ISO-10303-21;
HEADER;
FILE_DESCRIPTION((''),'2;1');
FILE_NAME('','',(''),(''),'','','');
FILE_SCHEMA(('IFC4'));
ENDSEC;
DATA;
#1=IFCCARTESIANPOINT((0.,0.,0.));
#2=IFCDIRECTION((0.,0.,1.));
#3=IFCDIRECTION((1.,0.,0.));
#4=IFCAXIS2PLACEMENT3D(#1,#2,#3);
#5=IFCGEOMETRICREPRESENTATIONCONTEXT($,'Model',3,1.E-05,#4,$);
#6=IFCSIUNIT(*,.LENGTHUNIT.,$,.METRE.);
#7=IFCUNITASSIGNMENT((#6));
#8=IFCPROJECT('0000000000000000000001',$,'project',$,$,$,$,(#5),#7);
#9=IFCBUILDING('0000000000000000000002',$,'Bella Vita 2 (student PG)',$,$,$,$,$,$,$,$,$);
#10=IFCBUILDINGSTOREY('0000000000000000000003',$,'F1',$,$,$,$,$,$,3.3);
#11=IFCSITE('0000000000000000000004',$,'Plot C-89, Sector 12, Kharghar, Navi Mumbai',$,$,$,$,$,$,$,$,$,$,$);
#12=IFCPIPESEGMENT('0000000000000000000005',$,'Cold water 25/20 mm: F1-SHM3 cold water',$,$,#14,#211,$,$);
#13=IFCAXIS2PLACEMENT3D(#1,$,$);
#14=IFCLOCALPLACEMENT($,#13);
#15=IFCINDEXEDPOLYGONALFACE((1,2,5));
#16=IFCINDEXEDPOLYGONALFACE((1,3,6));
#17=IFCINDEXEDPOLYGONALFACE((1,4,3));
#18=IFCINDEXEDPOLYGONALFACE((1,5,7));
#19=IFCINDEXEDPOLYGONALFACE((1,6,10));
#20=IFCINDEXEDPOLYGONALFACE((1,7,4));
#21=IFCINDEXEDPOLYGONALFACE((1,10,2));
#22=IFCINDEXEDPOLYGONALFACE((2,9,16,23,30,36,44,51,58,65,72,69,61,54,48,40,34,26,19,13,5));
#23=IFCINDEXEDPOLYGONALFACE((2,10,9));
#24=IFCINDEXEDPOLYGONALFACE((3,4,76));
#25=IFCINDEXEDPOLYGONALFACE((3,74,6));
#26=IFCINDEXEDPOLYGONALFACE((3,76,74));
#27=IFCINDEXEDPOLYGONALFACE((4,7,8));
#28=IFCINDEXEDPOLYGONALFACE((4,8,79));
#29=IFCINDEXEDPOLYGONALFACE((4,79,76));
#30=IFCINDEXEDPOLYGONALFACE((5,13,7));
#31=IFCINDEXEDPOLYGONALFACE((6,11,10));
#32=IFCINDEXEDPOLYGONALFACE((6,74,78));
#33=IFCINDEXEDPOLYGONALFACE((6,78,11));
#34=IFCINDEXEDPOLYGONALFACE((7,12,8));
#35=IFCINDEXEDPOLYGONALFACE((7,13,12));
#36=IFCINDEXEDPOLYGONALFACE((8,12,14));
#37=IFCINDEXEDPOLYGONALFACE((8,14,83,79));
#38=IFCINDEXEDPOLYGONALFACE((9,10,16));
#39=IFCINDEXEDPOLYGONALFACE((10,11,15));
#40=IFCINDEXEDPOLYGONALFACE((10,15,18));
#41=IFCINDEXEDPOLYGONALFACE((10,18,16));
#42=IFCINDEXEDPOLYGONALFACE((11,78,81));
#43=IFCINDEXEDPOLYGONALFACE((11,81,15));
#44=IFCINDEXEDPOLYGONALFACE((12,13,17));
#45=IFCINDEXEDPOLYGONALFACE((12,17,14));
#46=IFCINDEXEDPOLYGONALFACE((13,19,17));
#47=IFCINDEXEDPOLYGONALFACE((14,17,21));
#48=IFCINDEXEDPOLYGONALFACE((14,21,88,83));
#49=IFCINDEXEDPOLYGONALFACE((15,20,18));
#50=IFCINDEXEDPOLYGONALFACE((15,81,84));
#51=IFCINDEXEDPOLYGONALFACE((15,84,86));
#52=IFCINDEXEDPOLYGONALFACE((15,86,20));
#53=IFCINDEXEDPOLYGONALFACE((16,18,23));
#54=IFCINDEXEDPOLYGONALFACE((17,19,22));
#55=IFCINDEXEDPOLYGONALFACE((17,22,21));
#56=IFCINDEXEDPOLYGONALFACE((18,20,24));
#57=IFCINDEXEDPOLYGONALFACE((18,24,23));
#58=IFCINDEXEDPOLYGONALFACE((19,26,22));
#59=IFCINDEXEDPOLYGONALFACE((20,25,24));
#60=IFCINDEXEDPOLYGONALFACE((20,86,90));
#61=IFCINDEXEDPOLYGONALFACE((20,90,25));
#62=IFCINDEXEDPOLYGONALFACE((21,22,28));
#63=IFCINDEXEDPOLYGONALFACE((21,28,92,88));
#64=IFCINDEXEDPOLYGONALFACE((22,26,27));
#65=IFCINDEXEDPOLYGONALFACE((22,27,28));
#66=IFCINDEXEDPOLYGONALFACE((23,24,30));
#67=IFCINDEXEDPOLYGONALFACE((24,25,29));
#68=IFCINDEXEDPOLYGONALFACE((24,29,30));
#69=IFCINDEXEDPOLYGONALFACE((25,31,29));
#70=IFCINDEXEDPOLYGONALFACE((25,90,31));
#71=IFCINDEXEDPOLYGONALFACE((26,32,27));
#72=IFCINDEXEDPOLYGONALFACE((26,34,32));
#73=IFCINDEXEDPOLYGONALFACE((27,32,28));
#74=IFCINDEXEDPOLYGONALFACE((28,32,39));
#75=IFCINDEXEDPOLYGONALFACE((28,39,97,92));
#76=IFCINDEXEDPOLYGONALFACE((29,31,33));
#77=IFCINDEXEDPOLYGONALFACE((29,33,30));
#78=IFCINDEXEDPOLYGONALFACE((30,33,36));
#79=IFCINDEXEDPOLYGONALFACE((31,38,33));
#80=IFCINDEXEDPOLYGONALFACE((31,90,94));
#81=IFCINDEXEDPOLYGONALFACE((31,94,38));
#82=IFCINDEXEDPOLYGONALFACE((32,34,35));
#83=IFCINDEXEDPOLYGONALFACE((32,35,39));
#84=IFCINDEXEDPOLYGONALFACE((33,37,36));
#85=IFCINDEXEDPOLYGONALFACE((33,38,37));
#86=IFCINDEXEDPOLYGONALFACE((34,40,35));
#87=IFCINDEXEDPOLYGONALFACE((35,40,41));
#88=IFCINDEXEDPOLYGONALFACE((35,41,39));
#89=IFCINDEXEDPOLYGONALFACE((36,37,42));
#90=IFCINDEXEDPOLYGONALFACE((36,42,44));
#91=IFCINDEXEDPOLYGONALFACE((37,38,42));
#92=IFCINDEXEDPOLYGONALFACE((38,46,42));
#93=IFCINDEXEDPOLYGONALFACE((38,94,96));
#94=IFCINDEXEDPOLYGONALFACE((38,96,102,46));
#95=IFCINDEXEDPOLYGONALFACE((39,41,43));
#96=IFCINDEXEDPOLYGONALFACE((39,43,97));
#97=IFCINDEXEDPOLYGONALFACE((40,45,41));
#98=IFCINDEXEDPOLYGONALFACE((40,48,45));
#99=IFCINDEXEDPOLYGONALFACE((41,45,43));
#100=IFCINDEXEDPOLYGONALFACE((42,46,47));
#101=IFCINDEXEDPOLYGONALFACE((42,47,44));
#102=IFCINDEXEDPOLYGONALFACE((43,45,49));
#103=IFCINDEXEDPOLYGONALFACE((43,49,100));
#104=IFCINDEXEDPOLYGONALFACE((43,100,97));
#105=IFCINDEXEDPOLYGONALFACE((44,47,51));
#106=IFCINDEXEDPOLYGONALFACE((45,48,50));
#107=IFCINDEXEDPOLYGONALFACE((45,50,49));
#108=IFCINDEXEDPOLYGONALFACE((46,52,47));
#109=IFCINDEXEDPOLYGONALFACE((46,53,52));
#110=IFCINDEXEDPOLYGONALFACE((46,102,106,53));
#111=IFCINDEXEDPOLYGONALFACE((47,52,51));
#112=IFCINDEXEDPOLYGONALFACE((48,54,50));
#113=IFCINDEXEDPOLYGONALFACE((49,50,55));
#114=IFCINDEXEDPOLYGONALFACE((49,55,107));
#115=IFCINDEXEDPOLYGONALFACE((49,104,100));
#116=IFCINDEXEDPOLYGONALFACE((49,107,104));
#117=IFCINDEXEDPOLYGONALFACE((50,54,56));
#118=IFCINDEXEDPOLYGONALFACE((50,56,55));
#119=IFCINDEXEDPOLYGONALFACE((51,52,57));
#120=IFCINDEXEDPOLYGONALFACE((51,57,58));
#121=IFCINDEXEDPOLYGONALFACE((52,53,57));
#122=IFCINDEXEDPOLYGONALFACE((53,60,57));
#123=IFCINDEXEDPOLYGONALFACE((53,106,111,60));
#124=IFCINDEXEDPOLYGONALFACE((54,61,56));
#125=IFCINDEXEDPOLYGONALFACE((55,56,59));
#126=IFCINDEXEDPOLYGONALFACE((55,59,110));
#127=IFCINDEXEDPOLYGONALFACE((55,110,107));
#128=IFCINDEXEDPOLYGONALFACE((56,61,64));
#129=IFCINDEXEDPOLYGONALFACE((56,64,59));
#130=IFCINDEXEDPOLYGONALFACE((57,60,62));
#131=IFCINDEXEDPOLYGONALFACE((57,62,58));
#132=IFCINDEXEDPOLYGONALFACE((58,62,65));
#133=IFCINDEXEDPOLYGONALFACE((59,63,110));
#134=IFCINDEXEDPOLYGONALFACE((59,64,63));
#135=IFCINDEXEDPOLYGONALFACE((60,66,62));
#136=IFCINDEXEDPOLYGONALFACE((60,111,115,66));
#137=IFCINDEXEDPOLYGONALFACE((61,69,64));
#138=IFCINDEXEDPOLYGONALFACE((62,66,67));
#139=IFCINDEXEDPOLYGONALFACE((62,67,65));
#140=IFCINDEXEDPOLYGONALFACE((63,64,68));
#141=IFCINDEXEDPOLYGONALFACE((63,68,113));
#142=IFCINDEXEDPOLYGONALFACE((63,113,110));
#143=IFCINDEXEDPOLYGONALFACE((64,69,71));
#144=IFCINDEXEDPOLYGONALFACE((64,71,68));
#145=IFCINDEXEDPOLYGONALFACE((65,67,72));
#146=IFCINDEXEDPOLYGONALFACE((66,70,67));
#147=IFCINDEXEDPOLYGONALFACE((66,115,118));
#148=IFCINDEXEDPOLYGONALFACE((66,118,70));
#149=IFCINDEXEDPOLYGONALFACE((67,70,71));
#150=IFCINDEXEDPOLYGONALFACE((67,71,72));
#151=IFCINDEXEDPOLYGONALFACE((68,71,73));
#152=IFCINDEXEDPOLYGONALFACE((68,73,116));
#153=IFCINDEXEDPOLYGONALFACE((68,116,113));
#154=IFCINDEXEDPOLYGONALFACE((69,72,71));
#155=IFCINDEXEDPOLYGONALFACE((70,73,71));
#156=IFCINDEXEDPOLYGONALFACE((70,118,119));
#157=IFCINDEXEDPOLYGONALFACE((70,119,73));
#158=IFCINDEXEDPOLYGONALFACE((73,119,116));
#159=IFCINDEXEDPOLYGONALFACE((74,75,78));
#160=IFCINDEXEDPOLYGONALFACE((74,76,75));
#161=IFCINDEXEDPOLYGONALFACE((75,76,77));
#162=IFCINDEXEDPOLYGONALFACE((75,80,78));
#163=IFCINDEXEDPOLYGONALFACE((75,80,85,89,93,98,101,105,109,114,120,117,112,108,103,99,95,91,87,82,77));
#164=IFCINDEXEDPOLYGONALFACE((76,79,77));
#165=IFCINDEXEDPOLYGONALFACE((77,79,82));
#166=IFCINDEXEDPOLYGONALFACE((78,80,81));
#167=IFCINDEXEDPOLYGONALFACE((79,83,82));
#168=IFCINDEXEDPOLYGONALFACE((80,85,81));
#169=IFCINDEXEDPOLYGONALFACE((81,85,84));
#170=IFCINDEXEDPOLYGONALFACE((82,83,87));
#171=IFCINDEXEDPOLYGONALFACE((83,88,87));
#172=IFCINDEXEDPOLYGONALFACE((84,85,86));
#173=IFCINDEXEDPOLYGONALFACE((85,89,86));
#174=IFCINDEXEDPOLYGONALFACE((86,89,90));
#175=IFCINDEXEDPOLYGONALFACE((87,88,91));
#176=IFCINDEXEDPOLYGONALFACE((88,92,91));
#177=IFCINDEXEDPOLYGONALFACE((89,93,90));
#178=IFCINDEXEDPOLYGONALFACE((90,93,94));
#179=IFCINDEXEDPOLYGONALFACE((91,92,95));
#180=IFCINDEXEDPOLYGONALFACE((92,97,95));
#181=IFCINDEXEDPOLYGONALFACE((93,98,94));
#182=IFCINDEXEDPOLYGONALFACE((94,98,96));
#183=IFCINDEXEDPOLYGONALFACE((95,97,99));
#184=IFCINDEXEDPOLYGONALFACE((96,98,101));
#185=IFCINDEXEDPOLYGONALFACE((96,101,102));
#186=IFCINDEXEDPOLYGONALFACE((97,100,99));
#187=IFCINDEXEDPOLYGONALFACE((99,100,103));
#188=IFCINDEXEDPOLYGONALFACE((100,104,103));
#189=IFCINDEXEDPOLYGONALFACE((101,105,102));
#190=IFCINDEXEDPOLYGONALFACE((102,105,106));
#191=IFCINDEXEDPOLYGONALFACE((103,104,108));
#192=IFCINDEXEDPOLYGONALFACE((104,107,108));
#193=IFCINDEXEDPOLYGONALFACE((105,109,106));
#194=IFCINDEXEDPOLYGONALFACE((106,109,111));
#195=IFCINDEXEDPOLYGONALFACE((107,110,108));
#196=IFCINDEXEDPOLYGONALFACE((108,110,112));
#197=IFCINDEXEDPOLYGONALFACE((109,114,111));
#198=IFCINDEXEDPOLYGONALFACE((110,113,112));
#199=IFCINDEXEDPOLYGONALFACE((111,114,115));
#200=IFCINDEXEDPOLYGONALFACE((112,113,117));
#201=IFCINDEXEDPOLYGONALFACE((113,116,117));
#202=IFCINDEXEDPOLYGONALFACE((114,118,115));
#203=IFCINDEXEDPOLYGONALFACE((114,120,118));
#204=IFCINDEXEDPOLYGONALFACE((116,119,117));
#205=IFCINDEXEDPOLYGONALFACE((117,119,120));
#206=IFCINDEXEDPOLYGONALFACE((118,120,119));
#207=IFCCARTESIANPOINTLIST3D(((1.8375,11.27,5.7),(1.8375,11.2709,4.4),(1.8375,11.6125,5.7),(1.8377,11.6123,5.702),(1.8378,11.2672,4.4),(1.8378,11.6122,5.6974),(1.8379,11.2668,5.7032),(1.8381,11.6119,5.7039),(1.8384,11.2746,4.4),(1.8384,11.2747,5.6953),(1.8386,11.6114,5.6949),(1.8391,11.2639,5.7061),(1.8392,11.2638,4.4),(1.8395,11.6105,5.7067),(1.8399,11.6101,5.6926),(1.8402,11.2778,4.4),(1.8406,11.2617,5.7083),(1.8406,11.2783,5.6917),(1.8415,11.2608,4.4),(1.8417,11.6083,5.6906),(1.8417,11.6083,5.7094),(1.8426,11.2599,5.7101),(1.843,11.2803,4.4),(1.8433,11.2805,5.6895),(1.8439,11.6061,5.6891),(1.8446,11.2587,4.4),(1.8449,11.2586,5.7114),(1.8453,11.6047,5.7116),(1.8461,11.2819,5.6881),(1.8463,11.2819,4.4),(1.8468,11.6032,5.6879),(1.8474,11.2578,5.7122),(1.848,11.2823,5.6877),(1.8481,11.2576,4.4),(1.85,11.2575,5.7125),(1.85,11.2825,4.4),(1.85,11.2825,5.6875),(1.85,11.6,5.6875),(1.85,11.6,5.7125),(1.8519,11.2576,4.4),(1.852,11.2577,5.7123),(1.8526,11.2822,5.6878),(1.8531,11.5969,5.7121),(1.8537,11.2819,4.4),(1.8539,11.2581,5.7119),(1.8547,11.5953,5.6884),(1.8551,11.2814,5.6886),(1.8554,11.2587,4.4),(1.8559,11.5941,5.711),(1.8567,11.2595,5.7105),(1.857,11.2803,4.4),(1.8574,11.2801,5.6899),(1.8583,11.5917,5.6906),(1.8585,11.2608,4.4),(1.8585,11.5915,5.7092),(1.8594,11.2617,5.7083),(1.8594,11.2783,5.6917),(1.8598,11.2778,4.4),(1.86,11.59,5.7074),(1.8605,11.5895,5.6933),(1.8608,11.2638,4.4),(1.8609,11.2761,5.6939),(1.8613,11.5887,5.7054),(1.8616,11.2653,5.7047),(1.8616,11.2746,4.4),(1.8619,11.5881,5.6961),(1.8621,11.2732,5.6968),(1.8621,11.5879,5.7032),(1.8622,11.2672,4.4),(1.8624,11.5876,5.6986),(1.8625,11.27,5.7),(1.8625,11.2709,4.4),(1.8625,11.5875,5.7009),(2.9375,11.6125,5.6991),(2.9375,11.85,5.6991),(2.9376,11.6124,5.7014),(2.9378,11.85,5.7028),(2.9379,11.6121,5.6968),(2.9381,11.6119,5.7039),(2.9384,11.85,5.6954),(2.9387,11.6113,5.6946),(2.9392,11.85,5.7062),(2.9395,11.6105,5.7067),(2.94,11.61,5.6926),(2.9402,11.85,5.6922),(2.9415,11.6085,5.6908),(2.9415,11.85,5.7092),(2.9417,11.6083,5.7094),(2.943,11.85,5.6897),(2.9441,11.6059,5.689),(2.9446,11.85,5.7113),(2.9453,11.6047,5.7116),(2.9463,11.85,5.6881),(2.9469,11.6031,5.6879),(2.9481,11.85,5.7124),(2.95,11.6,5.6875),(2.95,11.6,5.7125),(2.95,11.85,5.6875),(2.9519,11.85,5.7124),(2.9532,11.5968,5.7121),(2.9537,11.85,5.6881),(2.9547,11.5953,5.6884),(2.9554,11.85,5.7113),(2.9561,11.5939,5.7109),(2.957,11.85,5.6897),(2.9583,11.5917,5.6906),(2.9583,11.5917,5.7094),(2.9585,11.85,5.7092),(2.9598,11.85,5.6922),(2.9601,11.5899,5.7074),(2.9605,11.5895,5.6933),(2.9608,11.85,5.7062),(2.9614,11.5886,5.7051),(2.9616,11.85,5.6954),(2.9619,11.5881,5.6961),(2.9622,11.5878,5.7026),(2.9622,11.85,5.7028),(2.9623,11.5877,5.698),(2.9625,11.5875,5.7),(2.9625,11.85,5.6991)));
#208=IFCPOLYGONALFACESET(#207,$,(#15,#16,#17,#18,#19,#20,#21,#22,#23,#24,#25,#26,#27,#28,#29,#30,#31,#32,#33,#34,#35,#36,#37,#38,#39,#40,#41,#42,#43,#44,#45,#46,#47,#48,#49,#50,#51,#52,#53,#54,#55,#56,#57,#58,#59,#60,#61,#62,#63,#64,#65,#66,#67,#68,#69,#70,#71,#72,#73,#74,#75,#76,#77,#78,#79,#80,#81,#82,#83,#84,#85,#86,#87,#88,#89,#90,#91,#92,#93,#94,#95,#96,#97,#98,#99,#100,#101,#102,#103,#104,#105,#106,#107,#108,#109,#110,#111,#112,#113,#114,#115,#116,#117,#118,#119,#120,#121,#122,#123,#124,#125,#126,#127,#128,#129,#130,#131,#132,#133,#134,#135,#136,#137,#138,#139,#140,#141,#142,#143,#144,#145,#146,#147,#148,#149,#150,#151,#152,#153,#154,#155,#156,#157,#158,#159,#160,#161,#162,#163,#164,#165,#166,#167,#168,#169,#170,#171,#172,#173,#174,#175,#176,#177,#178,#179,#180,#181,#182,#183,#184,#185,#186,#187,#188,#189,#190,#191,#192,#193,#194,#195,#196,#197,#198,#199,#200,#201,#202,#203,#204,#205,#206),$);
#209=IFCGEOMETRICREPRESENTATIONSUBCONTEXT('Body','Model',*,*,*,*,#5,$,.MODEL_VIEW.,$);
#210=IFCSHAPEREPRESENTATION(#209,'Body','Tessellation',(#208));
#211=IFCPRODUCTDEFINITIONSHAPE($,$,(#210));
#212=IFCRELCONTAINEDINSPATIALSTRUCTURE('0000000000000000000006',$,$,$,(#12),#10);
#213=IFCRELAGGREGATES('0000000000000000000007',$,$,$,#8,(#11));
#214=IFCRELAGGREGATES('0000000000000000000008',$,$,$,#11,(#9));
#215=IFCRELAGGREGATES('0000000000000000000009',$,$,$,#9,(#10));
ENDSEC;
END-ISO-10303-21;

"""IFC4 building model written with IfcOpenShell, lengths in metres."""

from ifc_helpers import new_model, entity, si_unit, origin, origin_with_axes, place, context, subcontext, project, spatial, element, save


model = new_model("IFC4")

# Units and contexts
model_context = context("Model", 3, precision=1e-05, world=origin_with_axes())
body_context = subcontext(model_context, "Body", "Model", "MODEL_VIEW")
ifc_project = project(units=[si_unit("LENGTHUNIT", "METRE")], contexts=[model_context])

# Site, building, storey
site = spatial("IfcSite", under=ifc_project, Name="Plot C-89, Sector 12, Kharghar, Navi Mumbai")
building = spatial("IfcBuilding", under=site, Name="Bella Vita 2 (student PG)")
storey = spatial("IfcBuildingStorey", under=building, Name="F1", Elevation=3.3)

# Pipe segment
pipe_segment_1_placement = place(None, origin())
element("IfcPipeSegment", 1, at=pipe_segment_1_placement, inside=storey, Name="Cold water 25/20 mm: F1-SHM3 cold water", context=body_context, shape_type="AdvancedSweptSolid", body=[
    entity("IfcSweptDiskSolid", entity("IfcPolyline", [entity("IfcCartesianPoint", [2.95, 11.85, 5.7]), entity("IfcCartesianPoint", [2.95, 11.6, 5.7]), entity("IfcCartesianPoint", [1.85, 11.6, 5.7]), entity("IfcCartesianPoint", [1.85, 11.27, 5.7]), entity("IfcCartesianPoint", [1.85, 11.27, 4.4])]), 0.0125),
])

save(model, "model.ifc")
